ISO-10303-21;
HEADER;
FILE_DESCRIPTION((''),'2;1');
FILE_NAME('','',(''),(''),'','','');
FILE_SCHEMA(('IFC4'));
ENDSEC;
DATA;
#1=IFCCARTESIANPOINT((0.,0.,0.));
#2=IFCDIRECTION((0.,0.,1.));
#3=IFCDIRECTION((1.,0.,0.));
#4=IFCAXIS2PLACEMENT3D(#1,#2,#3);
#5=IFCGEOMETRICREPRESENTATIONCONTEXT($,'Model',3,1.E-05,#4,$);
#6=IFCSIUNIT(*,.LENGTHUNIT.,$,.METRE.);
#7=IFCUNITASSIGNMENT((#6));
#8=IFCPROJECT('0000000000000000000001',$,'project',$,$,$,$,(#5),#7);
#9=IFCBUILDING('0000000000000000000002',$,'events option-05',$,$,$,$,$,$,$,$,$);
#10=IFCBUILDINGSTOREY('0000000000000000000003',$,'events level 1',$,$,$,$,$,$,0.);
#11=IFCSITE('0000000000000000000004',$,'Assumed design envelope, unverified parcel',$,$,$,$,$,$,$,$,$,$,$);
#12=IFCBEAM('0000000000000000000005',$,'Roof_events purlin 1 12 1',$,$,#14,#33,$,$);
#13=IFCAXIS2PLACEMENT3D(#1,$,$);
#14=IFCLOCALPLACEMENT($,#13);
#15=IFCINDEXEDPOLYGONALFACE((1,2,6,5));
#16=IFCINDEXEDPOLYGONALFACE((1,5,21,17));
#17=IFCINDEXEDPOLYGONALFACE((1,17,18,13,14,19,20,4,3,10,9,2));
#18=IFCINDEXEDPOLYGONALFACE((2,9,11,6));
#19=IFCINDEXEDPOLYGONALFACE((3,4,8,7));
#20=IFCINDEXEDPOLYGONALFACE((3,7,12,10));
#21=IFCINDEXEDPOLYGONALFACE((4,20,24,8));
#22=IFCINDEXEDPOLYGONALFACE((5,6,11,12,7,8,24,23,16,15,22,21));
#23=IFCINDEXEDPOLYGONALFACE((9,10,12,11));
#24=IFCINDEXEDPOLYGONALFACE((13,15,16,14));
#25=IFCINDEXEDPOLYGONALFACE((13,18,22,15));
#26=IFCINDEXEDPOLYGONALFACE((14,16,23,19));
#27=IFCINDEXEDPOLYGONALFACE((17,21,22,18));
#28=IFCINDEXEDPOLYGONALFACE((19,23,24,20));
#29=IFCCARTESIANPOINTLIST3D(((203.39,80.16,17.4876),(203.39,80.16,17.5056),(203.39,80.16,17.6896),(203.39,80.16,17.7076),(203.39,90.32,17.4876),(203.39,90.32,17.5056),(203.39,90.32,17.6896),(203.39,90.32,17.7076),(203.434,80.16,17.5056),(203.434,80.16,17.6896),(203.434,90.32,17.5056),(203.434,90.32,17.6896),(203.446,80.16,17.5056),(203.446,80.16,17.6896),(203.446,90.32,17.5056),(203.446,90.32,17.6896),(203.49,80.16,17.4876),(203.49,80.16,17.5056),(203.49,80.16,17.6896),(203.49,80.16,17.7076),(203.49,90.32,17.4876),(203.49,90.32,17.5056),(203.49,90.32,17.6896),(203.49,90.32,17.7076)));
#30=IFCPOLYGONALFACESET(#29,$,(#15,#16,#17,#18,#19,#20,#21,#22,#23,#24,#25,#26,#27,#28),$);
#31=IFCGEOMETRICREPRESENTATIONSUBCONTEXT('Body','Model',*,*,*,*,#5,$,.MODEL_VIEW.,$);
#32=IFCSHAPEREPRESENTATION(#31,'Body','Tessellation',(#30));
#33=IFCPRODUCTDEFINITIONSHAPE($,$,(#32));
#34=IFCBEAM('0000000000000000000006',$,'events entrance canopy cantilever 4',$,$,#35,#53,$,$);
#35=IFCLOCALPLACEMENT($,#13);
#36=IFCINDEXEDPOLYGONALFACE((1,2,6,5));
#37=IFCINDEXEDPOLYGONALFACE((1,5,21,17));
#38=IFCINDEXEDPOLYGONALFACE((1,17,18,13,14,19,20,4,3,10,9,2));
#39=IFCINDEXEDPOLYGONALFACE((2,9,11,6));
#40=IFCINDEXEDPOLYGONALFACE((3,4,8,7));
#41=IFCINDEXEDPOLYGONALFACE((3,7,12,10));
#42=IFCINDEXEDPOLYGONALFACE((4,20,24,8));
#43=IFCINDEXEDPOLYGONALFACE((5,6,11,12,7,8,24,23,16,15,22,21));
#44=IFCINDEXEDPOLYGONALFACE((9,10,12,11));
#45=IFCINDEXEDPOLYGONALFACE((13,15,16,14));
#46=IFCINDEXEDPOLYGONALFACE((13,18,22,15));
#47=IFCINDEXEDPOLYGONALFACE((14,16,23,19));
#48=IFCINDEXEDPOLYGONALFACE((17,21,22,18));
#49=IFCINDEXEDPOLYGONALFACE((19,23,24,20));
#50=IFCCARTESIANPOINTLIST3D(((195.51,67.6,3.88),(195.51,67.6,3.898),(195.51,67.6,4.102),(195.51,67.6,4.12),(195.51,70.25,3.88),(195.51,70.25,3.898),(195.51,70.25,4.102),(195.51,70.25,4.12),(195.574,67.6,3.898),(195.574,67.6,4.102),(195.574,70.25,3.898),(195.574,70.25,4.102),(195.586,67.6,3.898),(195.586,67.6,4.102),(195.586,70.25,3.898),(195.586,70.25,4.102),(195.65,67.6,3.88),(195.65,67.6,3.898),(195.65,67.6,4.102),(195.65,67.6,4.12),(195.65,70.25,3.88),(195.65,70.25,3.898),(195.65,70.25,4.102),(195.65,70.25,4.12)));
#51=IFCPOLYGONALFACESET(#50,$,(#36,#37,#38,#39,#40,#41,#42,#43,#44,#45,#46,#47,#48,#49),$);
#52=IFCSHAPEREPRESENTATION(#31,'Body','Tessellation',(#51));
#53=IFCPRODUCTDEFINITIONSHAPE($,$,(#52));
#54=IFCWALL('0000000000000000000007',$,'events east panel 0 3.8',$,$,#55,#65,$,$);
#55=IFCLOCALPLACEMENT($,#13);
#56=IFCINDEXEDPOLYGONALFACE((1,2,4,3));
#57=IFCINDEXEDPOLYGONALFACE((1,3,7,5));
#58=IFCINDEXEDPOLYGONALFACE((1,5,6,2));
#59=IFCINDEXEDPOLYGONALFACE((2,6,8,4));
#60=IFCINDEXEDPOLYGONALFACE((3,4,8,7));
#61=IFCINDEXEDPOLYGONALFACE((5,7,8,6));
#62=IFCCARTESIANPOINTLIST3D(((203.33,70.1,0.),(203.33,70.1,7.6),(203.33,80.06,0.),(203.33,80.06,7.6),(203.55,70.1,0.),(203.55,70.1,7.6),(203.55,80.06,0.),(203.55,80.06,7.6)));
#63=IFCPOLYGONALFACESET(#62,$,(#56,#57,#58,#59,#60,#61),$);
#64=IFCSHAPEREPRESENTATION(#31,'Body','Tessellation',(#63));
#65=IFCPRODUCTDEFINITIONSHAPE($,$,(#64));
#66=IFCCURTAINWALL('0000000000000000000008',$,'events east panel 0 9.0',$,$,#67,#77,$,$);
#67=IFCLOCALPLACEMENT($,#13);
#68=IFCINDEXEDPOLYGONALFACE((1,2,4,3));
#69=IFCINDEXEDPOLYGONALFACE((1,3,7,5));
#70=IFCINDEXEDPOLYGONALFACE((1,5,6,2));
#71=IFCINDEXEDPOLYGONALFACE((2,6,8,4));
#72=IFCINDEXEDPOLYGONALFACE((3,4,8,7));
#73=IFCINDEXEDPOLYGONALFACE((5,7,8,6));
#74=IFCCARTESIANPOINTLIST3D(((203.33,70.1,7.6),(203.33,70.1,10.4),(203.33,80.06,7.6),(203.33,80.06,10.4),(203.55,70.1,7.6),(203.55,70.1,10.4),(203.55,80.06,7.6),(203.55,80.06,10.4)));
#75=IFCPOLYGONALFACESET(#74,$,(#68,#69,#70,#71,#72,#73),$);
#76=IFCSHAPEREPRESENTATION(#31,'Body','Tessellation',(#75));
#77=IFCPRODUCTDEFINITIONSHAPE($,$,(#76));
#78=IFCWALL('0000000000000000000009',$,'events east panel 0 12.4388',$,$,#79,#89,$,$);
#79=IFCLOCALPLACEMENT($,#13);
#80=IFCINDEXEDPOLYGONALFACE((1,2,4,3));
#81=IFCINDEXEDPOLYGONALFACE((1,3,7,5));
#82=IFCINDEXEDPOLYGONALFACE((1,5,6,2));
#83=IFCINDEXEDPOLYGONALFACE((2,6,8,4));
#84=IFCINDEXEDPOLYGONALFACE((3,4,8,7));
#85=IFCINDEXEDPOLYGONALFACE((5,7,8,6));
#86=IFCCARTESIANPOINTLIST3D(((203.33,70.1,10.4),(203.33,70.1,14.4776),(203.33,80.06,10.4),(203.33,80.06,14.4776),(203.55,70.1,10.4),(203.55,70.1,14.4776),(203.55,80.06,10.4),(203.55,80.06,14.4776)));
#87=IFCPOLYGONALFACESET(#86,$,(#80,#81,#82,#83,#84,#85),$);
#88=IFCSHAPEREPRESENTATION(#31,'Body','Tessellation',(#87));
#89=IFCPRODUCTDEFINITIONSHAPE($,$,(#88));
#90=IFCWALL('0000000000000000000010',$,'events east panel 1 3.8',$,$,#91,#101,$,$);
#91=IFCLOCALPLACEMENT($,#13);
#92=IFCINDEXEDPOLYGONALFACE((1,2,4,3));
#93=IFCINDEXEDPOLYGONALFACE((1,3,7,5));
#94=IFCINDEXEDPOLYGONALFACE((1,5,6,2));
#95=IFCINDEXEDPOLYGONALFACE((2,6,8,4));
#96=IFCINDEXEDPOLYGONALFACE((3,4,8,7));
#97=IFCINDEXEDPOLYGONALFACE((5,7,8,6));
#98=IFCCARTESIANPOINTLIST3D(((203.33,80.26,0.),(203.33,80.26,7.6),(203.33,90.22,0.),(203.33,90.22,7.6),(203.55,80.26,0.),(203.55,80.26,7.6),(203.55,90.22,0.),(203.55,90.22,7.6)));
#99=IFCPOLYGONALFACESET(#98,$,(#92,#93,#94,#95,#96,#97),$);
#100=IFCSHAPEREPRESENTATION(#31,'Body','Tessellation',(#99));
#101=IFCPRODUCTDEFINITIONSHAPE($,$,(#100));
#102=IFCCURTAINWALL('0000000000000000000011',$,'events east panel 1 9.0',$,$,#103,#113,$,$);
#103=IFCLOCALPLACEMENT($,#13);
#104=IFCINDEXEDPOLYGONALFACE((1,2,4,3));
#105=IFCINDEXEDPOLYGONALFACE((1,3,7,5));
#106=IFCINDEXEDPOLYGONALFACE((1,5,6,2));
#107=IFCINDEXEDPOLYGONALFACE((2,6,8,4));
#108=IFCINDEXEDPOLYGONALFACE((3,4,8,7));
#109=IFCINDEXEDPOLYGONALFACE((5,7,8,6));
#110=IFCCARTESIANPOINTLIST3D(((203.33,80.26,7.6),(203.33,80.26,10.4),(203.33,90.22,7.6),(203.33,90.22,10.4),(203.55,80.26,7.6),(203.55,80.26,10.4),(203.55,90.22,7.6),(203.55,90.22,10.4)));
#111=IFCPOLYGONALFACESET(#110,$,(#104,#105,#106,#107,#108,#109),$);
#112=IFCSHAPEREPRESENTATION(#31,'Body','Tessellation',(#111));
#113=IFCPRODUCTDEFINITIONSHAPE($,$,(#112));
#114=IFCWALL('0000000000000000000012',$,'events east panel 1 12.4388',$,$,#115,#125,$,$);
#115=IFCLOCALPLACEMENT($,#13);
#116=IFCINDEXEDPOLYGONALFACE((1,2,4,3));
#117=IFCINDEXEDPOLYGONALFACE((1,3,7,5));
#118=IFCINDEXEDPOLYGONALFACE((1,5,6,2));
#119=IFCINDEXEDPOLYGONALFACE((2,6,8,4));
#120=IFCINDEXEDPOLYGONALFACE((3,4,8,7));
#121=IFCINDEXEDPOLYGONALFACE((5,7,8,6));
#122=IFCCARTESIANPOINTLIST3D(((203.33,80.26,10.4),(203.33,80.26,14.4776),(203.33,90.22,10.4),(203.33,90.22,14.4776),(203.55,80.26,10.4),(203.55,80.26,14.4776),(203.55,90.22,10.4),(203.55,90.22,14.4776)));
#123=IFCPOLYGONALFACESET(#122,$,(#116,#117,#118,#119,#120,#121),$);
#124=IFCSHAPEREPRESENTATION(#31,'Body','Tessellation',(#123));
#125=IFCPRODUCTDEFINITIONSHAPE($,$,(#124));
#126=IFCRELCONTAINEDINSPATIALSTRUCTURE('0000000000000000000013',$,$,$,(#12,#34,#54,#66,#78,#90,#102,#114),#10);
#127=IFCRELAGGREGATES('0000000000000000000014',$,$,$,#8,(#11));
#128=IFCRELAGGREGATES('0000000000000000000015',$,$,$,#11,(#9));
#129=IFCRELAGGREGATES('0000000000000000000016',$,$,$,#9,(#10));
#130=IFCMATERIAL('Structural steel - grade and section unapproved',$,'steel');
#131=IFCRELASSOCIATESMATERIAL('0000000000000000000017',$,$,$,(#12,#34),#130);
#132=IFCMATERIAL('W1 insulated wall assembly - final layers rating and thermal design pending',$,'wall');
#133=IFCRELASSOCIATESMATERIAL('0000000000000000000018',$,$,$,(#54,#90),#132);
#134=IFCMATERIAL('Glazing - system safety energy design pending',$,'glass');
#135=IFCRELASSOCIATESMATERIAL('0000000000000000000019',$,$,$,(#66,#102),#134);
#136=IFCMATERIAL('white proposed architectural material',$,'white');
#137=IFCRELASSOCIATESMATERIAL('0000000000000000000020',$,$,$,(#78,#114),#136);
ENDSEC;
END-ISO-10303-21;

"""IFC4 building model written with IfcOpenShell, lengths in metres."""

from ifc_helpers import new_model, si_unit, frame, origin_with_axes, place, context, subcontext, project, spatial, rectangle, i_section, extrude, material, element, save


model = new_model("IFC4")

# Units and contexts
model_context = context("Model", 3, precision=1e-05, world=origin_with_axes())
body_context = subcontext(model_context, "Body", "Model", "MODEL_VIEW")
ifc_project = project(units=[si_unit("LENGTHUNIT", "METRE")], contexts=[model_context])

# Site, building, storey
site = spatial("IfcSite", under=ifc_project, Name="Assumed design envelope, unverified parcel")
building = spatial("IfcBuilding", under=site, Name="events option-05")
storey = spatial("IfcBuildingStorey", under=building, Name="events level 1", Elevation=0.0)

# Shared definitions
ifc_material_1 = material(Name="Structural steel - grade and section unapproved", Category="steel")

# Beams
beam_1_placement = place(None, frame((203.44, 80.16, 17.5976), z_axis=(0.0, 1.0, 0.0), x_axis=(-1.0, 0.0, 0.0)))
element("IfcBeam", 1, at=beam_1_placement, inside=storey, material=ifc_material_1, Name="Roof_events purlin 1 12 1", context=body_context, shape_type="SweptSolid", body=[
    extrude(i_section(OverallWidth=0.1, OverallDepth=0.22, WebThickness=0.012, FlangeThickness=0.018, FilletRadius=0.0), origin_with_axes(), (0.0, 0.0, 1.0), 10.16),
])
beam_2_placement = place(None, frame((195.58, 70.25, 4.0), z_axis=(0.0, -1.0, 0.0), x_axis=(1.0, 0.0, 0.0)))
element("IfcBeam", 2, at=beam_2_placement, inside=storey, material=ifc_material_1, Name="events entrance canopy cantilever 4", context=body_context, shape_type="SweptSolid", body=[
    extrude(i_section(OverallWidth=0.14, OverallDepth=0.24, WebThickness=0.012, FlangeThickness=0.018, FilletRadius=0.0), origin_with_axes(), (0.0, 0.0, 1.0), 2.65),
])

# Wall
ifc_material_2 = material(Name="W1 insulated wall assembly - final layers rating and thermal design pending", Category="wall")
wall_1_placement = place(None, frame((203.44, 75.08, 0.0), z_axis=(0.0, 0.0, 1.0), x_axis=(1.0, 0.0, 0.0)))
element("IfcWall", 3, at=wall_1_placement, inside=storey, material=ifc_material_2, Name="events east panel 0 3.8", context=body_context, shape_type="SweptSolid", body=[
    extrude(rectangle(XDim=0.22, YDim=9.96), origin_with_axes(), (0.0, 0.0, 1.0), 7.6),
])

# Curtain wall
ifc_material_3 = material(Name="Glazing - system safety energy design pending", Category="glass")
curtain_wall_1_placement = place(None, frame((203.44, 75.08, 7.6), z_axis=(0.0, 0.0, 1.0), x_axis=(1.0, 0.0, 0.0)))
element("IfcCurtainWall", 4, at=curtain_wall_1_placement, inside=storey, material=ifc_material_3, Name="events east panel 0 9.0", context=body_context, shape_type="SweptSolid", body=[
    extrude(rectangle(XDim=0.22, YDim=9.96), origin_with_axes(), (0.0, 0.0, 1.0), 2.8),
])

# Walls
ifc_material_4 = material(Name="white proposed architectural material", Category="white")
wall_2_placement = place(None, frame((203.44, 75.08, 10.4), z_axis=(0.0, 0.0, 1.0), x_axis=(1.0, 0.0, 0.0)))
element("IfcWall", 5, at=wall_2_placement, inside=storey, material=ifc_material_4, Name="events east panel 0 12.4388", context=body_context, shape_type="SweptSolid", body=[
    extrude(rectangle(XDim=0.22, YDim=9.96), origin_with_axes(), (0.0, 0.0, 1.0), 4.0776),
])
wall_3_placement = place(None, frame((203.44, 85.24, 0.0), z_axis=(0.0, 0.0, 1.0), x_axis=(1.0, 0.0, 0.0)))
element("IfcWall", 6, at=wall_3_placement, inside=storey, material=ifc_material_2, Name="events east panel 1 3.8", context=body_context, shape_type="SweptSolid", body=[
    extrude(rectangle(XDim=0.22, YDim=9.96), origin_with_axes(), (0.0, 0.0, 1.0), 7.6),
])

# Curtain wall
curtain_wall_2_placement = place(None, frame((203.44, 85.24, 7.6), z_axis=(0.0, 0.0, 1.0), x_axis=(1.0, 0.0, 0.0)))
element("IfcCurtainWall", 7, at=curtain_wall_2_placement, inside=storey, material=ifc_material_3, Name="events east panel 1 9.0", context=body_context, shape_type="SweptSolid", body=[
    extrude(rectangle(XDim=0.22, YDim=9.96), origin_with_axes(), (0.0, 0.0, 1.0), 2.8),
])

# Wall
wall_4_placement = place(None, frame((203.44, 85.24, 10.4), z_axis=(0.0, 0.0, 1.0), x_axis=(1.0, 0.0, 0.0)))
element("IfcWall", 8, at=wall_4_placement, inside=storey, material=ifc_material_4, Name="events east panel 1 12.4388", context=body_context, shape_type="SweptSolid", body=[
    extrude(rectangle(XDim=0.22, YDim=9.96), origin_with_axes(), (0.0, 0.0, 1.0), 4.0776),
])

save(model, "model.ifc")
